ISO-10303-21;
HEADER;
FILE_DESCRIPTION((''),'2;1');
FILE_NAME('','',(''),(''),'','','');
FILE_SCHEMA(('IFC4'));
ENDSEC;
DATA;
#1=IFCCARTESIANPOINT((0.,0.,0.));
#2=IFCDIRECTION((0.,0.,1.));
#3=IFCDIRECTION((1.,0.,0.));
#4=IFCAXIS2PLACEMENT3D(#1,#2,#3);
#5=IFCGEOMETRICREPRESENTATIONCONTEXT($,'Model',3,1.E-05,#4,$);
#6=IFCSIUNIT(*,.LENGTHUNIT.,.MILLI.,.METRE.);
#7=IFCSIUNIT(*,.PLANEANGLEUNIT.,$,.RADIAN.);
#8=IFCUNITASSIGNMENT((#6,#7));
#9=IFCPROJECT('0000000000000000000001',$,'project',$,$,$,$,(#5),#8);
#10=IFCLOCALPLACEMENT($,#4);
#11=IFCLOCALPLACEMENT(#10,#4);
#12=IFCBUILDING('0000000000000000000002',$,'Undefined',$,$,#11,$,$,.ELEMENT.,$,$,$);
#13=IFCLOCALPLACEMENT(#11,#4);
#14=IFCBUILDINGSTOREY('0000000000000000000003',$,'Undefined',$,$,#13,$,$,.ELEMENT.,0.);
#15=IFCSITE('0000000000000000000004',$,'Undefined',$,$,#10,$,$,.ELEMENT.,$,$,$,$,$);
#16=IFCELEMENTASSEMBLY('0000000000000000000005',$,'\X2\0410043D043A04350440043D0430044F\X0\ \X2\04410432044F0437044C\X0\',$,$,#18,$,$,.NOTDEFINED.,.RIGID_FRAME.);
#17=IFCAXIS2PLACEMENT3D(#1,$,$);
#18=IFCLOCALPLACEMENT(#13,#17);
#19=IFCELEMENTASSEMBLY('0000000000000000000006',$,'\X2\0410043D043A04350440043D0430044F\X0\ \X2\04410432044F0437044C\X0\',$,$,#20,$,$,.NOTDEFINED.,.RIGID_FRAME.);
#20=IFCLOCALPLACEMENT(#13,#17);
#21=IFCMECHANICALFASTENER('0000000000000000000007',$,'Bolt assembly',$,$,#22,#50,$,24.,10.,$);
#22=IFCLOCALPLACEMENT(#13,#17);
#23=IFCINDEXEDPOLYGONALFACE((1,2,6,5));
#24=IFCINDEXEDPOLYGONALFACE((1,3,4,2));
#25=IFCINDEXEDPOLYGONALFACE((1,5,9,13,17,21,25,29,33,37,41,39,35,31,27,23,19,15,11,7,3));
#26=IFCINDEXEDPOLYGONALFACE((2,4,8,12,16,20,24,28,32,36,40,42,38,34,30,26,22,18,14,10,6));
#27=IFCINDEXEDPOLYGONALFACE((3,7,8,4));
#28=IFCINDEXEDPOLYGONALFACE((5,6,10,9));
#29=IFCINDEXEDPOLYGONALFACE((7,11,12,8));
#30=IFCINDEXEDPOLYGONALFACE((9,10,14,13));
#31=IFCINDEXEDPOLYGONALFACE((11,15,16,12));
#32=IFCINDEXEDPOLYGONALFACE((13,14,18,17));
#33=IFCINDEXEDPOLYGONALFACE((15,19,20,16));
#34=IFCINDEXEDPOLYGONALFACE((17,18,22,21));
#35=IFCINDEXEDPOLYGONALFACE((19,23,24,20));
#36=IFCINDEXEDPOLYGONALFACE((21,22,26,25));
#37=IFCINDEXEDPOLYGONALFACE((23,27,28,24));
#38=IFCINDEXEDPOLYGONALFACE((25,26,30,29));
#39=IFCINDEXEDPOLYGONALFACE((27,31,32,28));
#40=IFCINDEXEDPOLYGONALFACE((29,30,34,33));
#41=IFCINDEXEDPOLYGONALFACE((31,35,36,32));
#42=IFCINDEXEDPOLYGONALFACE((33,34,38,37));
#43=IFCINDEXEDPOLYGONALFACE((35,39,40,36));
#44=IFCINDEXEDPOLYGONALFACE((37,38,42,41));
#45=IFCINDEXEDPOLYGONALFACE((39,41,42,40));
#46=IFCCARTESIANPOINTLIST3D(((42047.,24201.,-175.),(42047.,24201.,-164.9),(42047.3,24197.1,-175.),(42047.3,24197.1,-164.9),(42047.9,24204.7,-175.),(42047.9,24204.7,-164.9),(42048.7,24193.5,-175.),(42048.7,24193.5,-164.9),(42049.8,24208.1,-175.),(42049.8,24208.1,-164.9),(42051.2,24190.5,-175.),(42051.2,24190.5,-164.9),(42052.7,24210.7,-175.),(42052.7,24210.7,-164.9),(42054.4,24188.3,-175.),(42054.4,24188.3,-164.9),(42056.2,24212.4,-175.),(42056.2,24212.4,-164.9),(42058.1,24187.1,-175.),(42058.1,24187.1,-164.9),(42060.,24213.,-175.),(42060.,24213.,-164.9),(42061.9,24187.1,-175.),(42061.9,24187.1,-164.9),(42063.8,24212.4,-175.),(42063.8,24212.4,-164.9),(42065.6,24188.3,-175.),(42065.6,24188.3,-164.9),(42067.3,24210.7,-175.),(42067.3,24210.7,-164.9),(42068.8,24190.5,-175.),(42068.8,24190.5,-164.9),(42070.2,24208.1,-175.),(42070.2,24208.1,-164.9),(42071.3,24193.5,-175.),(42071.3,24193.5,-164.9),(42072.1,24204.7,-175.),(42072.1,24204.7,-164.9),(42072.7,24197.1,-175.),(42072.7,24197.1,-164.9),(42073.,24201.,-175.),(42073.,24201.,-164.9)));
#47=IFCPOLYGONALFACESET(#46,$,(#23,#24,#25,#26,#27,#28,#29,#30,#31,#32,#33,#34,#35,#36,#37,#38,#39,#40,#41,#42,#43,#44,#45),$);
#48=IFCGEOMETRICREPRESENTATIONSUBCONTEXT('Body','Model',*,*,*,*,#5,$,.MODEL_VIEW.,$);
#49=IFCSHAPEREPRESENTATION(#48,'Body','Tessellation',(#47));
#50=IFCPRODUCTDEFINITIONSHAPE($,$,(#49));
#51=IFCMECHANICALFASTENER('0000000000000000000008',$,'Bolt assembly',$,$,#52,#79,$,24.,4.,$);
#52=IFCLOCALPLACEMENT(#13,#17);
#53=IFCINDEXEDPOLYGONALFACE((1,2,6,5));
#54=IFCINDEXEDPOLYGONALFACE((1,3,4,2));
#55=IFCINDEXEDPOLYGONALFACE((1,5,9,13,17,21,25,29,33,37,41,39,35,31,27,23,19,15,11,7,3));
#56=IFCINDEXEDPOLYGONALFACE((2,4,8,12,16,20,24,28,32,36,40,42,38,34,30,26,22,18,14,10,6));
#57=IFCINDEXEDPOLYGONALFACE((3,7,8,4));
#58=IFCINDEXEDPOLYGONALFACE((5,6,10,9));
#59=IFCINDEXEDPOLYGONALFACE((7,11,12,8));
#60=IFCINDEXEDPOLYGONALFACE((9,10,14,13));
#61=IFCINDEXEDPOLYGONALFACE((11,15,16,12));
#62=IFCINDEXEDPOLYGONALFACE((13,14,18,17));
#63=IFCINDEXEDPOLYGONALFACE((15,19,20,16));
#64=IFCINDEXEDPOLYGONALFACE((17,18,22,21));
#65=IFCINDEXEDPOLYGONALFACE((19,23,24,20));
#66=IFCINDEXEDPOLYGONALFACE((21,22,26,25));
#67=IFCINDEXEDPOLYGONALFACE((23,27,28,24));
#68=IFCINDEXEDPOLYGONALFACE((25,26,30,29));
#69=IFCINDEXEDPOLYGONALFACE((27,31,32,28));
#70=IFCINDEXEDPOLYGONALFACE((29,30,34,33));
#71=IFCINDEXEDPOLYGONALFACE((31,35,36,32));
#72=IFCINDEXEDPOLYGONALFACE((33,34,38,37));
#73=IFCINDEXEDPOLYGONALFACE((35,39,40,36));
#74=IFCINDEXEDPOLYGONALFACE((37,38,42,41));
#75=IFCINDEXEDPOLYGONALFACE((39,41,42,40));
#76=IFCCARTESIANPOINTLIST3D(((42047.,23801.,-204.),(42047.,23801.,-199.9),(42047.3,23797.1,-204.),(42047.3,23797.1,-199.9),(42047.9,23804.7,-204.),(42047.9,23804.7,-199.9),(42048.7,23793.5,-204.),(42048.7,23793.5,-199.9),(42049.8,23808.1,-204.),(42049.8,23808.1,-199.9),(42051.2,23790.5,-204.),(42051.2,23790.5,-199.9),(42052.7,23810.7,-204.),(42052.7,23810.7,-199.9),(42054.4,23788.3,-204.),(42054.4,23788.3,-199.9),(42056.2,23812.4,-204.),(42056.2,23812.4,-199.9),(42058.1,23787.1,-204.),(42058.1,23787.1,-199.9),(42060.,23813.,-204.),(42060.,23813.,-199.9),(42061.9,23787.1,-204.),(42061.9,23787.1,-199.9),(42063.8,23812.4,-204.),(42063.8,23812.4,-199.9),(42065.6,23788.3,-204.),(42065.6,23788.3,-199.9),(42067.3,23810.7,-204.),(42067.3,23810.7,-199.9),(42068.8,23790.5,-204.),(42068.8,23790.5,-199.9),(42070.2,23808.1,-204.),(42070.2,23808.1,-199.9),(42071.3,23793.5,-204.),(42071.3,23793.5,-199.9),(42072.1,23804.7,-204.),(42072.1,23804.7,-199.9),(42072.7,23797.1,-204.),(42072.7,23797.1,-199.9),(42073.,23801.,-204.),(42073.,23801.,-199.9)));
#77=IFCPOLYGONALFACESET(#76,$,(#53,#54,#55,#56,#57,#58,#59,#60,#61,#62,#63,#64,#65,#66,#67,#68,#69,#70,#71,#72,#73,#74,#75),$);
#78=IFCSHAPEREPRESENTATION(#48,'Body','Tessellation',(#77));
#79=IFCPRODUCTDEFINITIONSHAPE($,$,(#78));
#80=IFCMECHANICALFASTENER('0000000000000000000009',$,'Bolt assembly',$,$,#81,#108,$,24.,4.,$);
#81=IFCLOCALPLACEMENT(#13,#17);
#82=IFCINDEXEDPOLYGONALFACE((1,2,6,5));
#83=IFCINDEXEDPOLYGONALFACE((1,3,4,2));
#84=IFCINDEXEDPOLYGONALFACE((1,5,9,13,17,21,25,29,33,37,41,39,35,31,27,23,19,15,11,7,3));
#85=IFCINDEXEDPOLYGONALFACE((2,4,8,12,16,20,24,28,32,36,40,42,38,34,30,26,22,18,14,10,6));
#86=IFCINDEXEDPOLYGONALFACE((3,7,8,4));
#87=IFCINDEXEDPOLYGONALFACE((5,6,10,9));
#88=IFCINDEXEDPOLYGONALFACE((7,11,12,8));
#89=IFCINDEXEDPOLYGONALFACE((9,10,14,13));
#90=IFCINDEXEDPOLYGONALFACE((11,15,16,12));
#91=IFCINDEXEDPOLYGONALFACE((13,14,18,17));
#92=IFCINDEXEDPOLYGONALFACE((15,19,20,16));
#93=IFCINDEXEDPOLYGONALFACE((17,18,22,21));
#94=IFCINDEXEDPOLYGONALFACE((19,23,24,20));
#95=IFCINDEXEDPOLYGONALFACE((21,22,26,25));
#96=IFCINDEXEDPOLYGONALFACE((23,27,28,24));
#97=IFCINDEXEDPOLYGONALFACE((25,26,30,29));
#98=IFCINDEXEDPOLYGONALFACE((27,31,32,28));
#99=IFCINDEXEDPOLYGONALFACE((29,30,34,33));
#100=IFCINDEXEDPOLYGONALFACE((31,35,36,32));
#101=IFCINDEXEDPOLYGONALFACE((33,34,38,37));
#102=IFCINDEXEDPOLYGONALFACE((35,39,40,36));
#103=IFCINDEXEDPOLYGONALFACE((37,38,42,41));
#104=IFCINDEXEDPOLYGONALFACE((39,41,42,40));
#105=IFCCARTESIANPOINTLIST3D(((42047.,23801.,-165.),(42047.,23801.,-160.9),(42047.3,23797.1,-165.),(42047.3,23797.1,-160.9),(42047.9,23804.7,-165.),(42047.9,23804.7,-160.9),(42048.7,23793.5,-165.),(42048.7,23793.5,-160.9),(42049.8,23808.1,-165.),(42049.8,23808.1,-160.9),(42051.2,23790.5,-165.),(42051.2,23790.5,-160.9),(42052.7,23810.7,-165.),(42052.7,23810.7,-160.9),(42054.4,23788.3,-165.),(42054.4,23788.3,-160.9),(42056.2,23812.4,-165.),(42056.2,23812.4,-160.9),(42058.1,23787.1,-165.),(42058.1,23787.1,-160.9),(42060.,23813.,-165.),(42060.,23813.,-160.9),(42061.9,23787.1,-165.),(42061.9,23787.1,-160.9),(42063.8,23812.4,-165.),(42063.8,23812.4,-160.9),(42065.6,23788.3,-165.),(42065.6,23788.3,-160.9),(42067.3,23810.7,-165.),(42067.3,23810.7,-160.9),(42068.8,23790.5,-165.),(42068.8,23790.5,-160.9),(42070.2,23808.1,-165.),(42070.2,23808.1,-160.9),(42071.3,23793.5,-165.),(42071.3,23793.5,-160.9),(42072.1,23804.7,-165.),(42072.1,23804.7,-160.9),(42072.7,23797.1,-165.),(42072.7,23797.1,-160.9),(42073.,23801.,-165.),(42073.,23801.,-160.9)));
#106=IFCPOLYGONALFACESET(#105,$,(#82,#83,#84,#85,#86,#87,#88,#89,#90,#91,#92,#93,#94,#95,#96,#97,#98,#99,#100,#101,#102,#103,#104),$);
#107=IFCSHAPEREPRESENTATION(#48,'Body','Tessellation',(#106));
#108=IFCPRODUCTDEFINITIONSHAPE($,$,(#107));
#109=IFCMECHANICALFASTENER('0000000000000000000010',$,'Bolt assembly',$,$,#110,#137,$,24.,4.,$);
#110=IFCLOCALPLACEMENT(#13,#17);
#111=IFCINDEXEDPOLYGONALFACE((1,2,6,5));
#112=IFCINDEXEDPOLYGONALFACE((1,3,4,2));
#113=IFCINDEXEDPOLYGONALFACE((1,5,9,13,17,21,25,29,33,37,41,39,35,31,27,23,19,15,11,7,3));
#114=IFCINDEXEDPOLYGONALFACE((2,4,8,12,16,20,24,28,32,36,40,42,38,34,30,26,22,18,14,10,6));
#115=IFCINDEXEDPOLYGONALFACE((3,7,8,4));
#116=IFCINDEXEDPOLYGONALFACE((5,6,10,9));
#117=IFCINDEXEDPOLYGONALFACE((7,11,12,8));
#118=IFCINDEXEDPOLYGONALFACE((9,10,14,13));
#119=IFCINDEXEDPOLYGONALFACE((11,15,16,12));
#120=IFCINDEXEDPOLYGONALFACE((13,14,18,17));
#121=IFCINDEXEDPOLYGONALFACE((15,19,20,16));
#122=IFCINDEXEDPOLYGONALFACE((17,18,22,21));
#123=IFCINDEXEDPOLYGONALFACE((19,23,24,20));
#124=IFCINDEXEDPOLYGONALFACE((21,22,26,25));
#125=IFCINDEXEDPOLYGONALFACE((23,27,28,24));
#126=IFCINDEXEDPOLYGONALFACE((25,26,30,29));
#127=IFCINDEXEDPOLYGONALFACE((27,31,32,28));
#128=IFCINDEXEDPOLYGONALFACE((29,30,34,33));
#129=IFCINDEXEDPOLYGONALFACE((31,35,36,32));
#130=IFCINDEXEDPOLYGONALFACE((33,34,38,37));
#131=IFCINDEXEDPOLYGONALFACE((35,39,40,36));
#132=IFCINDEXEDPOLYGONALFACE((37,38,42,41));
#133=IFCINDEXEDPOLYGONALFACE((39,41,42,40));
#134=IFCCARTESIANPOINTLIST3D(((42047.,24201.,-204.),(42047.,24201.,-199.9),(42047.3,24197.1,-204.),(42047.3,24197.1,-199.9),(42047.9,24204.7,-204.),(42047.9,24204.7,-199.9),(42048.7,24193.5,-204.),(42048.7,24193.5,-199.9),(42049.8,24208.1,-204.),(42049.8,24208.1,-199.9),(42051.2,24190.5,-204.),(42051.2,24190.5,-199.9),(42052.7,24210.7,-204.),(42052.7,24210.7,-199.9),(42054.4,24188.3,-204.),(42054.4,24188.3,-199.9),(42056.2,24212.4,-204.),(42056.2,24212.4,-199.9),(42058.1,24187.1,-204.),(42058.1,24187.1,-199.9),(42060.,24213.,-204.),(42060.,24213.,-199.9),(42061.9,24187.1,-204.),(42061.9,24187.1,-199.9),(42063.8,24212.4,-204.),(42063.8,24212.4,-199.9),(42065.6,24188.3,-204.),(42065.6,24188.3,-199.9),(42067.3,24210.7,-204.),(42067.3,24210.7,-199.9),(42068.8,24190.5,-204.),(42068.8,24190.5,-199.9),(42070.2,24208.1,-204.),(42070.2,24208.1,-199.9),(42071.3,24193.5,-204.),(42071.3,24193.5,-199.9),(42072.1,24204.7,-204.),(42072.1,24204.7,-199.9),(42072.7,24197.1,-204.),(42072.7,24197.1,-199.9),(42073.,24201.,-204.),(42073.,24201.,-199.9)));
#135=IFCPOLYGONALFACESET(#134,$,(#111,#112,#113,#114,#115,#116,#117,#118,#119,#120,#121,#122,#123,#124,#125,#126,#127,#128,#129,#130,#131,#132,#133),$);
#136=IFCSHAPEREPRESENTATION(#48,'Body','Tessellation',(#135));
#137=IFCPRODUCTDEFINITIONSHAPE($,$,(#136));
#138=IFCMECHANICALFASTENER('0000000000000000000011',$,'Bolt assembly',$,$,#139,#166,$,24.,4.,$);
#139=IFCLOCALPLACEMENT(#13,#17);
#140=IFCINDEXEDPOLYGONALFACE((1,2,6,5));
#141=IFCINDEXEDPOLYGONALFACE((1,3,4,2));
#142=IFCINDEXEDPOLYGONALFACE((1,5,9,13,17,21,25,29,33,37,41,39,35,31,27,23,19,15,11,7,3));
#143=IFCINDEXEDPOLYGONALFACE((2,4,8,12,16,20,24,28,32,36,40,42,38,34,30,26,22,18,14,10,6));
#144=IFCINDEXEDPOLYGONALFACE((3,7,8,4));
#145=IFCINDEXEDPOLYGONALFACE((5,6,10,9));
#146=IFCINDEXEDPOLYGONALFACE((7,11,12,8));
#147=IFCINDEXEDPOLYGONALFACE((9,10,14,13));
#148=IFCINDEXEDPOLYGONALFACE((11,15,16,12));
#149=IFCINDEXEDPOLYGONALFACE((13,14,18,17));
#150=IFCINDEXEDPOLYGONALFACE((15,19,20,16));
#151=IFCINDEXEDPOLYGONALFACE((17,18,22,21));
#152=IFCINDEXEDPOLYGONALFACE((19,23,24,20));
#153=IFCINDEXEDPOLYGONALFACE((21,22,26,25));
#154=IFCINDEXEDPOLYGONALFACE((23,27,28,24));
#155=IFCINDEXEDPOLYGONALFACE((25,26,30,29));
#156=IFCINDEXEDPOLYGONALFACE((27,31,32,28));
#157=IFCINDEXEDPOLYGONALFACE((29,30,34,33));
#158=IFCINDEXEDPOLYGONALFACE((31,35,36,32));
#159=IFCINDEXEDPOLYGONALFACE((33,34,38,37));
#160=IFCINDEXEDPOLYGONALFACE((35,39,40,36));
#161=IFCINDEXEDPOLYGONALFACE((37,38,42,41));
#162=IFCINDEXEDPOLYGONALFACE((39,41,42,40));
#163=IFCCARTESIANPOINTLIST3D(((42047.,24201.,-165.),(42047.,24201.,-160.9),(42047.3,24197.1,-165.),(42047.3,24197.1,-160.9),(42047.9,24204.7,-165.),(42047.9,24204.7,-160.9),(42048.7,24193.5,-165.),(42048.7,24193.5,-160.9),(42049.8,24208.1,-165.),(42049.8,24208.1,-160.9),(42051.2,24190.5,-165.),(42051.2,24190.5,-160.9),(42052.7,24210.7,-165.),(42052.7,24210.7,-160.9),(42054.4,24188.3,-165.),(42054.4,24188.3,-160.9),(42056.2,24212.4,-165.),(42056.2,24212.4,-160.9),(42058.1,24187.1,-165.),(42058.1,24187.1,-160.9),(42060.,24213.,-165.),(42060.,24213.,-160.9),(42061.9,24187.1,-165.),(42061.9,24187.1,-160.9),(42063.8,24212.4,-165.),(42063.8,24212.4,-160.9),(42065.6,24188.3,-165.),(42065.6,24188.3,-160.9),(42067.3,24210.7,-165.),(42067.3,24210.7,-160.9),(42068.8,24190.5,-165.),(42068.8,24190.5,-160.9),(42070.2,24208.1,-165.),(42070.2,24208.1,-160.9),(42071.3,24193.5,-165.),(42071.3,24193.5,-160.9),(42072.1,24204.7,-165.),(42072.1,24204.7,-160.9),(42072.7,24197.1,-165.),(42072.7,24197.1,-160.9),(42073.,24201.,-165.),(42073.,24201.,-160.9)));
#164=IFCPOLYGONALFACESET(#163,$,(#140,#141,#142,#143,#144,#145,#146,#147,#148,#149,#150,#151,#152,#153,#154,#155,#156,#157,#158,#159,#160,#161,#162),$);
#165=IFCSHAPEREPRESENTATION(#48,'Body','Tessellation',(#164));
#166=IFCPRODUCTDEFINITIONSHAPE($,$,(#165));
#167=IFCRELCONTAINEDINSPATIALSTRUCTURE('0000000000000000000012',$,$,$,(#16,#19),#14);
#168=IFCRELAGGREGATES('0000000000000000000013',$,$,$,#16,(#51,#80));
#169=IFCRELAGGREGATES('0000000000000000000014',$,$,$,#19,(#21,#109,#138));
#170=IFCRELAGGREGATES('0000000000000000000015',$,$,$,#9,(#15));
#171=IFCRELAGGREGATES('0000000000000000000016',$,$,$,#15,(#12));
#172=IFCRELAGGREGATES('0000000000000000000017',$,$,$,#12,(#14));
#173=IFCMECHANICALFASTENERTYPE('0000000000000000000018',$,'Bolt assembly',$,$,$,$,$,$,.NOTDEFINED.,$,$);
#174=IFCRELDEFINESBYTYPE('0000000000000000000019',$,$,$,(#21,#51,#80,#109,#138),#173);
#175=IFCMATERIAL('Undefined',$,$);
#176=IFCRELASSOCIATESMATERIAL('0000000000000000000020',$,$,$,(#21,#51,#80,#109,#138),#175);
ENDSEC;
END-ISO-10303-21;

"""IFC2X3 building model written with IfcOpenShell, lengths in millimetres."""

from ifc_helpers import new_model, si_unit, frame, origin_with_axes, origin_2d_with_axis, place, context, subcontext, project, spatial, circle, extrude, source, transform, mapped, material, type_object, element, aggregate, save


model = new_model("IFC2X3")

# Units and contexts
model_context = context("Model", 3, precision=1e-05, world=origin_with_axes())
body_context = subcontext(model_context, "Body", "Model", "MODEL_VIEW")
ifc_project = project(units=[si_unit("LENGTHUNIT", "METRE", prefix="MILLI"), si_unit("PLANEANGLEUNIT", "RADIAN")], contexts=[model_context])

# Site, building, storey
site_placement = place(None, origin_with_axes())
site = spatial("IfcSite", under=ifc_project, at=site_placement, Name="Undefined", CompositionType="ELEMENT")
building_placement = place(site_placement, origin_with_axes())
building = spatial("IfcBuilding", under=site, at=building_placement, Name="Undefined", CompositionType="ELEMENT")
storey_placement = place(building_placement, origin_with_axes())
storey = spatial("IfcBuildingStorey", under=building, at=storey_placement, Name="Undefined", CompositionType="ELEMENT", Elevation=0.0)

# Element assembly
assembly_1_placement = place(storey_placement, origin_with_axes())
assembly_1 = element("IfcElementAssembly", 1, at=assembly_1_placement, inside=storey, Name="Анкерная связь", AssemblyPlace="NOTDEFINED", PredefinedType="RIGID_FRAME")

# Element assembly
assembly_2_placement = place(storey_placement, origin_with_axes())
assembly_2 = element("IfcElementAssembly", 2, at=assembly_2_placement, inside=storey, Name="Анкерная связь", AssemblyPlace="NOTDEFINED", PredefinedType="RIGID_FRAME")

# Shared definitions
ifc_material_1 = material(Name="Undefined")
mechanical_fastener_type = type_object("IfcMechanicalFastenerType", Name="Bolt assembly")

# Mechanical fasteners
shared_shape_1 = source(origin_with_axes(), body_context, "Body", "SweptSolid", [
    extrude(circle(Radius=13.0, at=origin_2d_with_axis()), frame((0.0, 0.0, 0.0), z_axis=(0.0, 1.0, 0.0), x_axis=(1.0, 0.0, 0.0)), (0.0, 0.0, 1.0), 10.1),
])
mechanical_fastener_1_placement = place(assembly_2_placement, frame((42060.0, 24200.0, -175.0), z_axis=(1.0, 0.0, 0.0), x_axis=(0.0, 1.0, 0.0)))
mechanical_fastener_1 = element("IfcMechanicalFastener", 3, at=mechanical_fastener_1_placement, type_object=mechanical_fastener_type, material=ifc_material_1, Name="Bolt assembly", NominalDiameter=24.0, NominalLength=10.0, context=body_context, shape_type="MappedRepresentation", body=[
    mapped(shared_shape_1, transform((0.0, 0.0, 0.0))),
])
shared_shape_2 = source(origin_with_axes(), body_context, "Body", "SweptSolid", [
    extrude(circle(Radius=13.0, at=origin_2d_with_axis()), frame((0.0, -4.0, 0.0), z_axis=(0.0, 1.0, 0.0), x_axis=(1.0, 0.0, 0.0)), (0.0, 0.0, 1.0), 4.1),
])
mechanical_fastener_2_placement = place(assembly_1_placement, frame((42060.0, 23800.0, -200.0), z_axis=(1.0, 0.0, 0.0), x_axis=(0.0, 1.0, 0.0)))
mechanical_fastener_2 = element("IfcMechanicalFastener", 4, at=mechanical_fastener_2_placement, type_object=mechanical_fastener_type, material=ifc_material_1, Name="Bolt assembly", NominalDiameter=24.0, NominalLength=4.0, context=body_context, shape_type="MappedRepresentation", body=[
    mapped(shared_shape_2, transform((0.0, 0.0, 0.0))),
])
mechanical_fastener_3_placement = place(assembly_1_placement, frame((42060.0, 23800.0, -161.0), z_axis=(1.0, 0.0, 0.0), x_axis=(0.0, 1.0, 0.0)))
mechanical_fastener_3 = element("IfcMechanicalFastener", 5, at=mechanical_fastener_3_placement, type_object=mechanical_fastener_type, material=ifc_material_1, Name="Bolt assembly", NominalDiameter=24.0, NominalLength=4.0, context=body_context, shape_type="MappedRepresentation", body=[
    mapped(shared_shape_2, transform((0.0, 0.0, 0.0))),
])
aggregate(assembly_1, [mechanical_fastener_2, mechanical_fastener_3])
mechanical_fastener_4_placement = place(assembly_2_placement, frame((42060.0, 24200.0, -200.0), z_axis=(1.0, 0.0, 0.0), x_axis=(0.0, 1.0, 0.0)))
mechanical_fastener_4 = element("IfcMechanicalFastener", 6, at=mechanical_fastener_4_placement, type_object=mechanical_fastener_type, material=ifc_material_1, Name="Bolt assembly", NominalDiameter=24.0, NominalLength=4.0, context=body_context, shape_type="MappedRepresentation", body=[
    mapped(shared_shape_2, transform((0.0, 0.0, 0.0))),
])
mechanical_fastener_5_placement = place(assembly_2_placement, frame((42060.0, 24200.0, -161.0), z_axis=(1.0, 0.0, 0.0), x_axis=(0.0, 1.0, 0.0)))
mechanical_fastener_5 = element("IfcMechanicalFastener", 7, at=mechanical_fastener_5_placement, type_object=mechanical_fastener_type, material=ifc_material_1, Name="Bolt assembly", NominalDiameter=24.0, NominalLength=4.0, context=body_context, shape_type="MappedRepresentation", body=[
    mapped(shared_shape_2, transform((0.0, 0.0, 0.0))),
])
aggregate(assembly_2, [mechanical_fastener_1, mechanical_fastener_4, mechanical_fastener_5])

save(model, "model.ifc")
